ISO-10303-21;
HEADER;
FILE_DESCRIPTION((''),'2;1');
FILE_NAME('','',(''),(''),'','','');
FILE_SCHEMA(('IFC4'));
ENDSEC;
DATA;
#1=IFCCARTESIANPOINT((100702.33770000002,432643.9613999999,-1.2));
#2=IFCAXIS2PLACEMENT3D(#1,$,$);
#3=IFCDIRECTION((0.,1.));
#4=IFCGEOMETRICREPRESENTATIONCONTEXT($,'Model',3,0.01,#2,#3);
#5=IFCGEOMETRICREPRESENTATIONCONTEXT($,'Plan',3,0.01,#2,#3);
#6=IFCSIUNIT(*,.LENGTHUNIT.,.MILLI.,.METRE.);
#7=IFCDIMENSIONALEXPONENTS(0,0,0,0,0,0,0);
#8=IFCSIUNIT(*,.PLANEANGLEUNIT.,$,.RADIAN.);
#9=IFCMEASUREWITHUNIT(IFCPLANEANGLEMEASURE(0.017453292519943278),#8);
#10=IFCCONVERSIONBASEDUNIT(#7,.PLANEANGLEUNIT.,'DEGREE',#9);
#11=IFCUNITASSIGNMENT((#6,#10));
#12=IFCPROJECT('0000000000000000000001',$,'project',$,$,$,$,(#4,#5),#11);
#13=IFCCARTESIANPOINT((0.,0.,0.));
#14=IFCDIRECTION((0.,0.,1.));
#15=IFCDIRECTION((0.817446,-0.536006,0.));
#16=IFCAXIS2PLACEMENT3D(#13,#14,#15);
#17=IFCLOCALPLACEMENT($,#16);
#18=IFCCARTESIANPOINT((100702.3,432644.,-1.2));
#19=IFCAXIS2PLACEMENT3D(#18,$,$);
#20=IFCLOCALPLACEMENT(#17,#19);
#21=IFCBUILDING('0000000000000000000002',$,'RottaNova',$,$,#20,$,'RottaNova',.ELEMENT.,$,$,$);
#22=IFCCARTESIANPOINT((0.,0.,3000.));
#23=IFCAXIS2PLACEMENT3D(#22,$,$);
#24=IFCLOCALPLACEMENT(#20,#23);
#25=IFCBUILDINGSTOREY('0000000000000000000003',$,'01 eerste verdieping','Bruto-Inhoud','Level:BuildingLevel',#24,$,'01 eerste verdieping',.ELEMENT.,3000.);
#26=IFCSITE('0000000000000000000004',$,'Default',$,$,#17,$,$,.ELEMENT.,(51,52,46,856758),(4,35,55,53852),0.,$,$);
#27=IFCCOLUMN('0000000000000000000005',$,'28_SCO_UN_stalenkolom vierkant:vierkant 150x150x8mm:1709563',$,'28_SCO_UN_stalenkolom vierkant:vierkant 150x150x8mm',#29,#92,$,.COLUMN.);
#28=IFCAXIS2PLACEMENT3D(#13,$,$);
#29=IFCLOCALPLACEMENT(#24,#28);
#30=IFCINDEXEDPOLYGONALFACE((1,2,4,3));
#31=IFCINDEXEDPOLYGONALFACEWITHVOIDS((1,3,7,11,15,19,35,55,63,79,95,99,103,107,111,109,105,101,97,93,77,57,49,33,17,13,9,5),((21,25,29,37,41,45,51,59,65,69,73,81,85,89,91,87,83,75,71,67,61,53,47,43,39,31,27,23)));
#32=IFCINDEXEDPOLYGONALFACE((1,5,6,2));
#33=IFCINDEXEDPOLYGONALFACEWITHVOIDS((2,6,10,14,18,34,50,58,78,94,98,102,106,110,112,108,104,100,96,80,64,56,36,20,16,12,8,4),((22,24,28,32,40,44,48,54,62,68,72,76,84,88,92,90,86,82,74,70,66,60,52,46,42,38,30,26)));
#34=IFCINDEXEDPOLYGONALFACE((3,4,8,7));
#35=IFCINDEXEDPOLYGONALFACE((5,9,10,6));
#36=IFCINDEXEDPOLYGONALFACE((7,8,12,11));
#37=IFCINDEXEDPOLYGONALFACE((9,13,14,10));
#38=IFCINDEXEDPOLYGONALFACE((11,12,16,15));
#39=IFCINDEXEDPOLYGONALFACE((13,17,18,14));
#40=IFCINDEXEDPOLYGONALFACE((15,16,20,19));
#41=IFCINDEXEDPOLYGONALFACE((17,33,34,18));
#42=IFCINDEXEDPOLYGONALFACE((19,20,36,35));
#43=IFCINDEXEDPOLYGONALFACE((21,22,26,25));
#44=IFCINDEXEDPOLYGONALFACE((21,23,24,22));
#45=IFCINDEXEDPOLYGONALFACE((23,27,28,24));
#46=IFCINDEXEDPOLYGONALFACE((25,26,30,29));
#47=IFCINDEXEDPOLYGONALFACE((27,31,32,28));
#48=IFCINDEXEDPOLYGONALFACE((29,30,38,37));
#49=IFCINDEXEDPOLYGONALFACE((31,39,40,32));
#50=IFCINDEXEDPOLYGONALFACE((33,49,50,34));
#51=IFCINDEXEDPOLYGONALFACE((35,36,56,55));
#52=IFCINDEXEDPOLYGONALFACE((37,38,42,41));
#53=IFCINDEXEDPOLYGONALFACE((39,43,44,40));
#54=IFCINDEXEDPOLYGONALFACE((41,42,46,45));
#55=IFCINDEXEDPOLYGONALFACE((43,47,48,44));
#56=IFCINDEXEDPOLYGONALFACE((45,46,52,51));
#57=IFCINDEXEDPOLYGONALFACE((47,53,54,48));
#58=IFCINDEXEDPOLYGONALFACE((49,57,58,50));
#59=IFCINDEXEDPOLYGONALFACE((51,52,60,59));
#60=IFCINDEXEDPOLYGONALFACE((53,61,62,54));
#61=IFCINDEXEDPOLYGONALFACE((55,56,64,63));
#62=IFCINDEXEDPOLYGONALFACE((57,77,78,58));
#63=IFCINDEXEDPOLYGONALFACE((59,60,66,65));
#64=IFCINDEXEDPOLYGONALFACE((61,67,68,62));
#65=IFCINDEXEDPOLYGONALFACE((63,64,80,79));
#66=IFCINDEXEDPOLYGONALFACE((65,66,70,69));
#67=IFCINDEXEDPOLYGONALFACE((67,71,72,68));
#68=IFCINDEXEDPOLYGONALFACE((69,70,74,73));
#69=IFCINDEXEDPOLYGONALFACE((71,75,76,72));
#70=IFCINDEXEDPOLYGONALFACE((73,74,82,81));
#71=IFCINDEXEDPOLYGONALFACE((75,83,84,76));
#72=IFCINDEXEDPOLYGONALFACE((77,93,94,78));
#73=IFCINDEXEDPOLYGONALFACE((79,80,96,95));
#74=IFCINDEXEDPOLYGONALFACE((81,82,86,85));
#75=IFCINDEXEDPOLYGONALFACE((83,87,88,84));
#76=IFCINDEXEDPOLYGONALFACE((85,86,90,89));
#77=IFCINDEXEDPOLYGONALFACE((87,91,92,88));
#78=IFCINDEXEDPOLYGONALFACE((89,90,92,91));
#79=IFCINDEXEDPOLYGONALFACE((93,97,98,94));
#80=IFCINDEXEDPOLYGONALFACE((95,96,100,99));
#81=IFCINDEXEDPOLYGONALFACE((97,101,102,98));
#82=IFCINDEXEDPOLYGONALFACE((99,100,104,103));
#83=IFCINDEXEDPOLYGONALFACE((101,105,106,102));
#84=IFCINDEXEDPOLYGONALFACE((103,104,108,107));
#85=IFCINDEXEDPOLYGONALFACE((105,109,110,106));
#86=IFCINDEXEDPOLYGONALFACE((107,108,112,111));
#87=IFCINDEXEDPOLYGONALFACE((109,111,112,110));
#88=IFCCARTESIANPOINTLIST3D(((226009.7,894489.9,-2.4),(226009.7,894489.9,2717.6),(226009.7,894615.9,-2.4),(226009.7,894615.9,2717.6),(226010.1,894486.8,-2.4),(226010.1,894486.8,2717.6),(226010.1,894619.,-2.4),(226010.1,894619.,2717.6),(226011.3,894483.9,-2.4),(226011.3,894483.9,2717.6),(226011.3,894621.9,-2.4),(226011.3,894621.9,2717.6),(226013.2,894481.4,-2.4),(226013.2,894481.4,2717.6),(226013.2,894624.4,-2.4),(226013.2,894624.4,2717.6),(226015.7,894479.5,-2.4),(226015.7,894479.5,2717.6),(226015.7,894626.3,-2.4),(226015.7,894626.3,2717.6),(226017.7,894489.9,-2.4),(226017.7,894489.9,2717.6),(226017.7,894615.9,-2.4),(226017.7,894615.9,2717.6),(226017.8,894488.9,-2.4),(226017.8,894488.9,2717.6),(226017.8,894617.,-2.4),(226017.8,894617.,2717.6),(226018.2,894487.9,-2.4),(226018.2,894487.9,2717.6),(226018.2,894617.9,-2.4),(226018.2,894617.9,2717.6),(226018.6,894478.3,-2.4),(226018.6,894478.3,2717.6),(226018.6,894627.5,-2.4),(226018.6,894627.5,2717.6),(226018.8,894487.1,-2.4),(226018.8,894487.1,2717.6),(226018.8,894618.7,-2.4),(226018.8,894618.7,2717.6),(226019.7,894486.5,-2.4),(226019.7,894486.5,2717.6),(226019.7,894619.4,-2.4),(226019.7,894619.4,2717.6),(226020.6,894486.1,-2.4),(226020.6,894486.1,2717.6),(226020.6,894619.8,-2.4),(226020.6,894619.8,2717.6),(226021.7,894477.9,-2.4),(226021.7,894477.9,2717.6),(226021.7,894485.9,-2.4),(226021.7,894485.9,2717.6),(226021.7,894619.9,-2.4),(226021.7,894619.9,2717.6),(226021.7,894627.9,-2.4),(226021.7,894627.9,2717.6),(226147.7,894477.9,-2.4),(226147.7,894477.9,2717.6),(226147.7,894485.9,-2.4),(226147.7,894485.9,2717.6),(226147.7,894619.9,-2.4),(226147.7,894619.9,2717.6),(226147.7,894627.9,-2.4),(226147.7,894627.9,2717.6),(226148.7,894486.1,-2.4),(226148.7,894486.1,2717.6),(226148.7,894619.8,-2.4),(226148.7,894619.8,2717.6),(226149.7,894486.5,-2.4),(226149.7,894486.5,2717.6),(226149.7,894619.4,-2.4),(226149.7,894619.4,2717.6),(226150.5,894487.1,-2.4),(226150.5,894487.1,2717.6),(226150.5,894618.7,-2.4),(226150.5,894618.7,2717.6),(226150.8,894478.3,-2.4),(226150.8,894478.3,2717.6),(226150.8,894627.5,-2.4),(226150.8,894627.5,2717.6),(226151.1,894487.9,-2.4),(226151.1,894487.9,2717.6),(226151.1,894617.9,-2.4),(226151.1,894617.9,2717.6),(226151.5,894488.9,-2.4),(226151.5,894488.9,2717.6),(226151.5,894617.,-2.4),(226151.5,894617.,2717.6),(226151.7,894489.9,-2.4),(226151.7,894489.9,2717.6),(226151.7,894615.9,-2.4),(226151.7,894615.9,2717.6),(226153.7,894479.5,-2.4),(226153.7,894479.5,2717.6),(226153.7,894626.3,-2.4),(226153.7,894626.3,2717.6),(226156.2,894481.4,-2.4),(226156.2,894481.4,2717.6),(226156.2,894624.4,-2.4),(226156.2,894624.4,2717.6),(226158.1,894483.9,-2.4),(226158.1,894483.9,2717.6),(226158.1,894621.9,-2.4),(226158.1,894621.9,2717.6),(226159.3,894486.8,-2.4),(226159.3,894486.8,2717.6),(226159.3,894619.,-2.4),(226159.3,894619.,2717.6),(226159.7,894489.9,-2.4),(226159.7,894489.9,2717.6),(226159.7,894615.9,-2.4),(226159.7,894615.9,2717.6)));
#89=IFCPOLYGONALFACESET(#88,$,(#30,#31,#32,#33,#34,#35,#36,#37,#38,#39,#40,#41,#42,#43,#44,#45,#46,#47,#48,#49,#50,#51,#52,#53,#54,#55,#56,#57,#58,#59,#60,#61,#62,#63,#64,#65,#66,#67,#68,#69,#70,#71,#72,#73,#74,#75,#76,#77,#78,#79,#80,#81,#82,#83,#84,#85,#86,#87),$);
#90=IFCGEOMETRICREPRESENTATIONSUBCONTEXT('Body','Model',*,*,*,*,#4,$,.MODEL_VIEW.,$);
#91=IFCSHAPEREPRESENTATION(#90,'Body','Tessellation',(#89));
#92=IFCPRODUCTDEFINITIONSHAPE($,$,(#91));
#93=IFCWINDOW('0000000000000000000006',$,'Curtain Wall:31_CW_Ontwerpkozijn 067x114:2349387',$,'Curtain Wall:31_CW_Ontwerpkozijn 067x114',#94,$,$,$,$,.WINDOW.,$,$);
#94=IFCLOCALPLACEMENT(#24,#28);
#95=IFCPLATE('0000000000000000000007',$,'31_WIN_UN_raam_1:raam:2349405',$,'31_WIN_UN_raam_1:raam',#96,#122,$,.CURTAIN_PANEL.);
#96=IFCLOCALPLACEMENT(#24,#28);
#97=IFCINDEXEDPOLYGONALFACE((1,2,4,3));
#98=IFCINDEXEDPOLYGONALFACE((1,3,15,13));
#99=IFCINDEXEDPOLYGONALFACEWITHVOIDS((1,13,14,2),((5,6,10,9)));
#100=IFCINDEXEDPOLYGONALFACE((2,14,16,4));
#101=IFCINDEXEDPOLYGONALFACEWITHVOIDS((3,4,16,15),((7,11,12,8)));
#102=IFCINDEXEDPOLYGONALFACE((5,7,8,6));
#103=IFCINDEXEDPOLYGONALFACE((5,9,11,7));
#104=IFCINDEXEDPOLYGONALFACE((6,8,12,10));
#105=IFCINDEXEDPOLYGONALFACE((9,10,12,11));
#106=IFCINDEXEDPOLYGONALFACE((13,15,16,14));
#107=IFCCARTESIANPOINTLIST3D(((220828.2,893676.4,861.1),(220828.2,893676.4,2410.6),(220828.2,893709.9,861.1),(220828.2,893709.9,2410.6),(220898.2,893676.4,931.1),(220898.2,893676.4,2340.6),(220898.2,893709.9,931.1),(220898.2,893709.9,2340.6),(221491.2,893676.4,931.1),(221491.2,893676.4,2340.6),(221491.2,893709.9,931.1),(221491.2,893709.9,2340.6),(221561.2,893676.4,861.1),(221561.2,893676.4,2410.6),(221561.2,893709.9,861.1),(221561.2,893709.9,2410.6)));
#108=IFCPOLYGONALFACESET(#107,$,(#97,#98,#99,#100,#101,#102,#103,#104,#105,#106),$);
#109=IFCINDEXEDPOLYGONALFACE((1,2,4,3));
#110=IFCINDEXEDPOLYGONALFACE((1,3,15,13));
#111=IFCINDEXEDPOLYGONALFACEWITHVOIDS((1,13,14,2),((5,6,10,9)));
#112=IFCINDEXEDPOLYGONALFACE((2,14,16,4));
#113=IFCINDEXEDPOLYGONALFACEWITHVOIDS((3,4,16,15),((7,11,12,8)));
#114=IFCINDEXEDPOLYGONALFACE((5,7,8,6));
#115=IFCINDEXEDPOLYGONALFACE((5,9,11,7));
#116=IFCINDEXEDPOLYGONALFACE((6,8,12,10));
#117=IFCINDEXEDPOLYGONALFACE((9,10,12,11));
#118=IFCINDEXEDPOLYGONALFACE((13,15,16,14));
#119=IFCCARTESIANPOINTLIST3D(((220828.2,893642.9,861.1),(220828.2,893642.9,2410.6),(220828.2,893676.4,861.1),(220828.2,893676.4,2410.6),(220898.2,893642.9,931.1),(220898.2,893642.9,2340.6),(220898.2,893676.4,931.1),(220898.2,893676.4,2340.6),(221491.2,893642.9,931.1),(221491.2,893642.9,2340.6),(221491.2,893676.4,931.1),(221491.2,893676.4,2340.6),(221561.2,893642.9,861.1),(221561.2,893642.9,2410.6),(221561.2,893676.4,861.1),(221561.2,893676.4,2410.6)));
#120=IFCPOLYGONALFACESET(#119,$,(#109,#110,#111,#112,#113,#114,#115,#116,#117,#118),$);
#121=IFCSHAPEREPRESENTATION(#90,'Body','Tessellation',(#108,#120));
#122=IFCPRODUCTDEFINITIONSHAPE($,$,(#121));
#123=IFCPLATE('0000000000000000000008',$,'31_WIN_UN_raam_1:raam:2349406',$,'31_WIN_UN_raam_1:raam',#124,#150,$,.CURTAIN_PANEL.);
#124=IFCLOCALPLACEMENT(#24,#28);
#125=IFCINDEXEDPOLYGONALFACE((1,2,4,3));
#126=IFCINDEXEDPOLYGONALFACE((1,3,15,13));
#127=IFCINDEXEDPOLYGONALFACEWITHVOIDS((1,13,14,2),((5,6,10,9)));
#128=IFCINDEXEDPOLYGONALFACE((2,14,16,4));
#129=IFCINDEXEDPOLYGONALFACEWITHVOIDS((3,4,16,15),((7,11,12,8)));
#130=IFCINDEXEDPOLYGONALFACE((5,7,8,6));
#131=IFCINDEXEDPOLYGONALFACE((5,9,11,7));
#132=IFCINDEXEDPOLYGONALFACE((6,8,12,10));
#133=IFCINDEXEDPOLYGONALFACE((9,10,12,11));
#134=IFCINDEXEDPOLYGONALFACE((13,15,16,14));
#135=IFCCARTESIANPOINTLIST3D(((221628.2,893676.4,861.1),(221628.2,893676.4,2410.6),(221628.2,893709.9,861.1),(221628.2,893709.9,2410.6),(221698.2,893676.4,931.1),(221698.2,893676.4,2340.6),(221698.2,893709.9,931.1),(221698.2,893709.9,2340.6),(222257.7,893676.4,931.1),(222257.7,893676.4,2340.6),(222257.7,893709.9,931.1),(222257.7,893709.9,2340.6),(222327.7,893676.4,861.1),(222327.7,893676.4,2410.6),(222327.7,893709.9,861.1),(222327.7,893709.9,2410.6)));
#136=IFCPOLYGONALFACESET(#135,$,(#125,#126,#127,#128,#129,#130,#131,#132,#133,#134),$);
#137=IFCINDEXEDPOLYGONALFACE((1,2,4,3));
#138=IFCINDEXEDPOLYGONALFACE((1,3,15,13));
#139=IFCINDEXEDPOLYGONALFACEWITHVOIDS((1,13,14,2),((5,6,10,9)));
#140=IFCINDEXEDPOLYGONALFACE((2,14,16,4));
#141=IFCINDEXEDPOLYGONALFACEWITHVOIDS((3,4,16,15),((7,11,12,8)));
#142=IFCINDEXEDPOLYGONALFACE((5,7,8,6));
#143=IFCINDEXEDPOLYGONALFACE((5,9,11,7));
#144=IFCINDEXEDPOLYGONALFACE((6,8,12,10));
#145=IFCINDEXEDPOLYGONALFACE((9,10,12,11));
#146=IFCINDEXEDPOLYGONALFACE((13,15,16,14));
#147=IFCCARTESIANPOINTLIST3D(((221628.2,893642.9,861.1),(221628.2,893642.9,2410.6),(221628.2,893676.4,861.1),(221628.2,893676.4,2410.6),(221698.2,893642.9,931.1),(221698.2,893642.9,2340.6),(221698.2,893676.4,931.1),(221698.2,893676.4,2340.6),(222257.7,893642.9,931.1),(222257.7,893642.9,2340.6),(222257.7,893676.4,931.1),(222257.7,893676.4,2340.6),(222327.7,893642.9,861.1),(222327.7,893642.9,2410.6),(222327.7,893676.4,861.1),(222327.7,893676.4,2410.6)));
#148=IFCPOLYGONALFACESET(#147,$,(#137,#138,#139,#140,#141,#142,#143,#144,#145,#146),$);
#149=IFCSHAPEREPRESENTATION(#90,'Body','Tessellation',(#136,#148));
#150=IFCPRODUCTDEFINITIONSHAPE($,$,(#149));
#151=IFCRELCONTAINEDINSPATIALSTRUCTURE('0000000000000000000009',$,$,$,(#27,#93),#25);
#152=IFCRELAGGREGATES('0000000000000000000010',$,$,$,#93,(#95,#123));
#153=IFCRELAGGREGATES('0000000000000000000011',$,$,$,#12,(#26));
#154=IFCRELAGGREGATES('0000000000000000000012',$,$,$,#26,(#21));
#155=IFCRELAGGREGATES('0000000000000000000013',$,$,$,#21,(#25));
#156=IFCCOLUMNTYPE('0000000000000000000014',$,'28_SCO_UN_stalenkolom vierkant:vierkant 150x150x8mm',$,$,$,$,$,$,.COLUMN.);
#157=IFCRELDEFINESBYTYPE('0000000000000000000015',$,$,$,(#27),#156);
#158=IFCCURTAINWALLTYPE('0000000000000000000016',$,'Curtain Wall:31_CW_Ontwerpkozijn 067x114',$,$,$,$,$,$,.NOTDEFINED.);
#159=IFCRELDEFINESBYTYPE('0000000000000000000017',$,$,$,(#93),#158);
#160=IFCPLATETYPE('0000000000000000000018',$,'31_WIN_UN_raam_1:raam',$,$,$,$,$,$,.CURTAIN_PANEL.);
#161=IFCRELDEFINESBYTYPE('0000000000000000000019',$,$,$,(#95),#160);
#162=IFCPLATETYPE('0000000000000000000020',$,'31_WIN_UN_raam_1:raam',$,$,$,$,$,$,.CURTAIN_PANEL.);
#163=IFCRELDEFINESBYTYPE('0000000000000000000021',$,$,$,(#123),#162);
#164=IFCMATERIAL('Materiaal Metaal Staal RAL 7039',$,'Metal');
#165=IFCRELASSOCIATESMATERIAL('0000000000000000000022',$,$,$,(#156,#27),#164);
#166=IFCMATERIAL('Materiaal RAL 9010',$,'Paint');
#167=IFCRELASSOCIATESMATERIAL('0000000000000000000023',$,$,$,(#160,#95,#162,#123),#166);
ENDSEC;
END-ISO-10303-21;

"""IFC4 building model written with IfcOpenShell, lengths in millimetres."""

from ifc_helpers import new_model, entity, si_unit, converted_unit, direction, frame, place, context, subcontext, project, spatial, line, arc, indexed_curve, outline, extrude, source, transform, mapped, material, type_object, type_shapes, element, aggregate, save


model = new_model("IFC4")

# Units and contexts
model_context = context("Model", 3, precision=0.01, world=frame((100702.33770000002, 432643.9613999999, -1.2)), true_north=direction((0.0, 1.0)))
plan_context = context("Plan", 3, precision=0.01, world=frame((100702.33770000002, 432643.9613999999, -1.2)), true_north=direction((0.0, 1.0)))
body_context = subcontext(model_context, "Body", "Model", "MODEL_VIEW")
ifc_project = project(units=[si_unit("LENGTHUNIT", "METRE", prefix="MILLI"), converted_unit("PLANEANGLEUNIT", "DEGREE", entity("IfcPlaneAngleMeasure", 0.017453292519943278), si_unit("PLANEANGLEUNIT", "RADIAN"), dimensions=[0, 0, 0, 0, 0, 0, 0])], contexts=[model_context, plan_context])

# Site, building, storey
site_placement = place(None, frame((0.0, 0.0, 0.0), z_axis=(0.0, 0.0, 1.0), x_axis=(0.817446, -0.536006, 0.0)))
site = spatial("IfcSite", under=ifc_project, at=site_placement, Name="Default", CompositionType="ELEMENT", RefLatitude=(51, 52, 46, 856758), RefLongitude=(4, 35, 55, 53852), RefElevation=0.0)
building_placement = place(site_placement, frame((100702.3, 432644.0, -1.2)))
building = spatial("IfcBuilding", under=site, at=building_placement, Name="RottaNova", LongName="RottaNova", CompositionType="ELEMENT")
storey_placement = place(building_placement, frame((0.0, 0.0, 3000.0)))
storey = spatial("IfcBuildingStorey", under=building, at=storey_placement, Name="01 eerste verdieping", Description="Bruto-Inhoud", ObjectType="Level:BuildingLevel", LongName="01 eerste verdieping", CompositionType="ELEMENT", Elevation=3000.0)

# Column
ifc_material_1 = material(Name="Materiaal Metaal Staal RAL 7039", Category="Metal")
column_type = type_object("IfcColumnType", Name="28_SCO_UN_stalenkolom vierkant:vierkant 150x150x8mm", PredefinedType="COLUMN", material=ifc_material_1)
shared_shape_1 = source(frame((100702.3, 432644.0, -1.2)), body_context, "Body", "SweptSolid", [
    extrude(outline(indexed_curve([(-63.0, -75.0), (63.0, -75.0), (71.5, -71.5), (75.0, -63.0), (75.0, 63.0), (71.5, 71.5), (63.0, 75.0), (-63.0, 75.0), (-71.5, 71.5), (-75.0, 63.0), (-75.0, -63.0), (-71.5, -71.5)], segments=[line(1, 2), arc(2, 3, 4), line(4, 5), arc(5, 6, 7), line(7, 8), arc(8, 9, 10), line(10, 11), arc(11, 12, 1)], self_intersect=False), holes=[indexed_curve([(67.0, -63.0), (65.8, -65.8), (63.0, -67.0), (-63.0, -67.0), (-65.8, -65.8), (-67.0, -63.0), (-67.0, 63.0), (-65.8, 65.8), (-63.0, 67.0), (63.0, 67.0), (65.8, 65.8), (67.0, 63.0)], segments=[arc(1, 2, 3), line(3, 4), arc(4, 5, 6), line(6, 7), arc(7, 8, 9), line(9, 10), arc(10, 11, 12), line(12, 1)], self_intersect=False)]), frame((0.0, 0.0, 3000.0), z_axis=(0.0, 0.0, 1.0), x_axis=(-1.0, 0.0, 0.0)), (0.0, 0.0, 1.0), 2720.0),
])
type_shapes(column_type, [shared_shape_1])
column_placement = place(storey_placement, frame((24680.0, 29265.0, -3000.0)))
element("IfcColumn", 1, at=column_placement, inside=storey, type_object=column_type, material=ifc_material_1, Name="28_SCO_UN_stalenkolom vierkant:vierkant 150x150x8mm:1709563", ObjectType="28_SCO_UN_stalenkolom vierkant:vierkant 150x150x8mm", PredefinedType="COLUMN", context=body_context, shape_type="MappedRepresentation", body=[
    mapped(shared_shape_1, transform((100702.3, 432644.0, -1.2), scale=1.0)),
])

# Shared definitions
curtain_wall_type = type_object("IfcCurtainWallType", Name="Curtain Wall:31_CW_Ontwerpkozijn 067x114", PredefinedType="NOTDEFINED")

# Window, plates
window_1_placement = place(storey_placement, frame((0.0, 0.0, -3000.0)))
window_1 = element("IfcWindow", 2, at=window_1_placement, inside=storey, type_object=curtain_wall_type, Name="Curtain Wall:31_CW_Ontwerpkozijn 067x114:2349387", ObjectType="Curtain Wall:31_CW_Ontwerpkozijn 067x114", PredefinedType="WINDOW")
ifc_material_2 = material(Name="Materiaal RAL 9010", Category="Paint")
plate_type_1 = type_object("IfcPlateType", Name="31_WIN_UN_raam_1:raam", PredefinedType="CURTAIN_PANEL", material=ifc_material_2)
shared_shape_2 = source(frame((100702.3, 432644.0, -1.2)), body_context, "Body", "SweptSolid", [
    extrude(outline(indexed_curve([(-366.5, -774.8), (366.5, -774.8), (366.5, 774.8), (-366.5, 774.8), (-366.5, -774.8)], self_intersect=False), holes=[indexed_curve([(-296.5, 704.8), (296.5, 704.8), (296.5, -704.8), (-296.5, -704.8), (-296.5, 704.8)], self_intersect=False)]), frame((0.0, 58.5, 774.8), z_axis=(0.0, 1.0, 0.0), x_axis=(1.0, 0.0, 0.0)), (0.0, 0.0, 1.0), 33.5),
    extrude(outline(indexed_curve([(-366.5, -774.8), (366.5, -774.8), (366.5, 774.8), (-366.5, 774.8), (-366.5, -774.8)], self_intersect=False), holes=[indexed_curve([(-296.5, 704.7), (296.5, 704.7), (296.5, -704.8), (-296.5, -704.8), (-296.5, 704.7)], self_intersect=False)]), frame((0.0, 25.0, 774.8), z_axis=(0.0, 1.0, 0.0), x_axis=(1.0, 0.0, 0.0)), (0.0, 0.0, 1.0), 33.5),
])
type_shapes(plate_type_1, [shared_shape_2])
plate_1_placement = place(window_1_placement, frame((19790.0, 28330.0, 3863.5)))
plate_1 = element("IfcPlate", 3, at=plate_1_placement, type_object=plate_type_1, material=ifc_material_2, Name="31_WIN_UN_raam_1:raam:2349405", ObjectType="31_WIN_UN_raam_1:raam", PredefinedType="CURTAIN_PANEL", context=body_context, shape_type="MappedRepresentation", body=[
    mapped(shared_shape_2, transform((100702.3, 432644.0, -1.2), scale=1.0)),
])
plate_type_2 = type_object("IfcPlateType", Name="31_WIN_UN_raam_1:raam", PredefinedType="CURTAIN_PANEL", material=ifc_material_2)
shared_shape_3 = source(frame((100702.3, 432644.0, -1.2)), body_context, "Body", "SweptSolid", [
    extrude(outline(indexed_curve([(-349.7, -774.8), (349.7, -774.8), (349.7, 774.8), (-349.7, 774.8), (-349.7, -774.8)], self_intersect=False), holes=[indexed_curve([(-279.7, 704.8), (279.7, 704.8), (279.7, -704.8), (-279.7, -704.8), (-279.7, 704.8)], self_intersect=False)]), frame((0.0, 58.5, 774.8), z_axis=(0.0, 1.0, 0.0), x_axis=(1.0, 0.0, 0.0)), (0.0, 0.0, 1.0), 33.5),
    extrude(outline(indexed_curve([(-349.7, -774.8), (349.7, -774.8), (349.7, 774.8), (-349.7, 774.8), (-349.7, -774.8)], self_intersect=False), holes=[indexed_curve([(-279.7, 704.7), (279.7, 704.7), (279.7, -704.8), (-279.7, -704.8), (-279.7, 704.7)], self_intersect=False)]), frame((0.0, 25.0, 774.8), z_axis=(0.0, 1.0, 0.0), x_axis=(1.0, 0.0, 0.0)), (0.0, 0.0, 1.0), 33.5),
])
type_shapes(plate_type_2, [shared_shape_3])
plate_2_placement = place(window_1_placement, frame((20573.3, 28330.0, 3863.5)))
plate_2 = element("IfcPlate", 4, at=plate_2_placement, type_object=plate_type_2, material=ifc_material_2, Name="31_WIN_UN_raam_1:raam:2349406", ObjectType="31_WIN_UN_raam_1:raam", PredefinedType="CURTAIN_PANEL", context=body_context, shape_type="MappedRepresentation", body=[
    mapped(shared_shape_3, transform((100702.3, 432644.0, -1.2), scale=1.0)),
])
aggregate(window_1, [plate_1, plate_2])

save(model, "model.ifc")
